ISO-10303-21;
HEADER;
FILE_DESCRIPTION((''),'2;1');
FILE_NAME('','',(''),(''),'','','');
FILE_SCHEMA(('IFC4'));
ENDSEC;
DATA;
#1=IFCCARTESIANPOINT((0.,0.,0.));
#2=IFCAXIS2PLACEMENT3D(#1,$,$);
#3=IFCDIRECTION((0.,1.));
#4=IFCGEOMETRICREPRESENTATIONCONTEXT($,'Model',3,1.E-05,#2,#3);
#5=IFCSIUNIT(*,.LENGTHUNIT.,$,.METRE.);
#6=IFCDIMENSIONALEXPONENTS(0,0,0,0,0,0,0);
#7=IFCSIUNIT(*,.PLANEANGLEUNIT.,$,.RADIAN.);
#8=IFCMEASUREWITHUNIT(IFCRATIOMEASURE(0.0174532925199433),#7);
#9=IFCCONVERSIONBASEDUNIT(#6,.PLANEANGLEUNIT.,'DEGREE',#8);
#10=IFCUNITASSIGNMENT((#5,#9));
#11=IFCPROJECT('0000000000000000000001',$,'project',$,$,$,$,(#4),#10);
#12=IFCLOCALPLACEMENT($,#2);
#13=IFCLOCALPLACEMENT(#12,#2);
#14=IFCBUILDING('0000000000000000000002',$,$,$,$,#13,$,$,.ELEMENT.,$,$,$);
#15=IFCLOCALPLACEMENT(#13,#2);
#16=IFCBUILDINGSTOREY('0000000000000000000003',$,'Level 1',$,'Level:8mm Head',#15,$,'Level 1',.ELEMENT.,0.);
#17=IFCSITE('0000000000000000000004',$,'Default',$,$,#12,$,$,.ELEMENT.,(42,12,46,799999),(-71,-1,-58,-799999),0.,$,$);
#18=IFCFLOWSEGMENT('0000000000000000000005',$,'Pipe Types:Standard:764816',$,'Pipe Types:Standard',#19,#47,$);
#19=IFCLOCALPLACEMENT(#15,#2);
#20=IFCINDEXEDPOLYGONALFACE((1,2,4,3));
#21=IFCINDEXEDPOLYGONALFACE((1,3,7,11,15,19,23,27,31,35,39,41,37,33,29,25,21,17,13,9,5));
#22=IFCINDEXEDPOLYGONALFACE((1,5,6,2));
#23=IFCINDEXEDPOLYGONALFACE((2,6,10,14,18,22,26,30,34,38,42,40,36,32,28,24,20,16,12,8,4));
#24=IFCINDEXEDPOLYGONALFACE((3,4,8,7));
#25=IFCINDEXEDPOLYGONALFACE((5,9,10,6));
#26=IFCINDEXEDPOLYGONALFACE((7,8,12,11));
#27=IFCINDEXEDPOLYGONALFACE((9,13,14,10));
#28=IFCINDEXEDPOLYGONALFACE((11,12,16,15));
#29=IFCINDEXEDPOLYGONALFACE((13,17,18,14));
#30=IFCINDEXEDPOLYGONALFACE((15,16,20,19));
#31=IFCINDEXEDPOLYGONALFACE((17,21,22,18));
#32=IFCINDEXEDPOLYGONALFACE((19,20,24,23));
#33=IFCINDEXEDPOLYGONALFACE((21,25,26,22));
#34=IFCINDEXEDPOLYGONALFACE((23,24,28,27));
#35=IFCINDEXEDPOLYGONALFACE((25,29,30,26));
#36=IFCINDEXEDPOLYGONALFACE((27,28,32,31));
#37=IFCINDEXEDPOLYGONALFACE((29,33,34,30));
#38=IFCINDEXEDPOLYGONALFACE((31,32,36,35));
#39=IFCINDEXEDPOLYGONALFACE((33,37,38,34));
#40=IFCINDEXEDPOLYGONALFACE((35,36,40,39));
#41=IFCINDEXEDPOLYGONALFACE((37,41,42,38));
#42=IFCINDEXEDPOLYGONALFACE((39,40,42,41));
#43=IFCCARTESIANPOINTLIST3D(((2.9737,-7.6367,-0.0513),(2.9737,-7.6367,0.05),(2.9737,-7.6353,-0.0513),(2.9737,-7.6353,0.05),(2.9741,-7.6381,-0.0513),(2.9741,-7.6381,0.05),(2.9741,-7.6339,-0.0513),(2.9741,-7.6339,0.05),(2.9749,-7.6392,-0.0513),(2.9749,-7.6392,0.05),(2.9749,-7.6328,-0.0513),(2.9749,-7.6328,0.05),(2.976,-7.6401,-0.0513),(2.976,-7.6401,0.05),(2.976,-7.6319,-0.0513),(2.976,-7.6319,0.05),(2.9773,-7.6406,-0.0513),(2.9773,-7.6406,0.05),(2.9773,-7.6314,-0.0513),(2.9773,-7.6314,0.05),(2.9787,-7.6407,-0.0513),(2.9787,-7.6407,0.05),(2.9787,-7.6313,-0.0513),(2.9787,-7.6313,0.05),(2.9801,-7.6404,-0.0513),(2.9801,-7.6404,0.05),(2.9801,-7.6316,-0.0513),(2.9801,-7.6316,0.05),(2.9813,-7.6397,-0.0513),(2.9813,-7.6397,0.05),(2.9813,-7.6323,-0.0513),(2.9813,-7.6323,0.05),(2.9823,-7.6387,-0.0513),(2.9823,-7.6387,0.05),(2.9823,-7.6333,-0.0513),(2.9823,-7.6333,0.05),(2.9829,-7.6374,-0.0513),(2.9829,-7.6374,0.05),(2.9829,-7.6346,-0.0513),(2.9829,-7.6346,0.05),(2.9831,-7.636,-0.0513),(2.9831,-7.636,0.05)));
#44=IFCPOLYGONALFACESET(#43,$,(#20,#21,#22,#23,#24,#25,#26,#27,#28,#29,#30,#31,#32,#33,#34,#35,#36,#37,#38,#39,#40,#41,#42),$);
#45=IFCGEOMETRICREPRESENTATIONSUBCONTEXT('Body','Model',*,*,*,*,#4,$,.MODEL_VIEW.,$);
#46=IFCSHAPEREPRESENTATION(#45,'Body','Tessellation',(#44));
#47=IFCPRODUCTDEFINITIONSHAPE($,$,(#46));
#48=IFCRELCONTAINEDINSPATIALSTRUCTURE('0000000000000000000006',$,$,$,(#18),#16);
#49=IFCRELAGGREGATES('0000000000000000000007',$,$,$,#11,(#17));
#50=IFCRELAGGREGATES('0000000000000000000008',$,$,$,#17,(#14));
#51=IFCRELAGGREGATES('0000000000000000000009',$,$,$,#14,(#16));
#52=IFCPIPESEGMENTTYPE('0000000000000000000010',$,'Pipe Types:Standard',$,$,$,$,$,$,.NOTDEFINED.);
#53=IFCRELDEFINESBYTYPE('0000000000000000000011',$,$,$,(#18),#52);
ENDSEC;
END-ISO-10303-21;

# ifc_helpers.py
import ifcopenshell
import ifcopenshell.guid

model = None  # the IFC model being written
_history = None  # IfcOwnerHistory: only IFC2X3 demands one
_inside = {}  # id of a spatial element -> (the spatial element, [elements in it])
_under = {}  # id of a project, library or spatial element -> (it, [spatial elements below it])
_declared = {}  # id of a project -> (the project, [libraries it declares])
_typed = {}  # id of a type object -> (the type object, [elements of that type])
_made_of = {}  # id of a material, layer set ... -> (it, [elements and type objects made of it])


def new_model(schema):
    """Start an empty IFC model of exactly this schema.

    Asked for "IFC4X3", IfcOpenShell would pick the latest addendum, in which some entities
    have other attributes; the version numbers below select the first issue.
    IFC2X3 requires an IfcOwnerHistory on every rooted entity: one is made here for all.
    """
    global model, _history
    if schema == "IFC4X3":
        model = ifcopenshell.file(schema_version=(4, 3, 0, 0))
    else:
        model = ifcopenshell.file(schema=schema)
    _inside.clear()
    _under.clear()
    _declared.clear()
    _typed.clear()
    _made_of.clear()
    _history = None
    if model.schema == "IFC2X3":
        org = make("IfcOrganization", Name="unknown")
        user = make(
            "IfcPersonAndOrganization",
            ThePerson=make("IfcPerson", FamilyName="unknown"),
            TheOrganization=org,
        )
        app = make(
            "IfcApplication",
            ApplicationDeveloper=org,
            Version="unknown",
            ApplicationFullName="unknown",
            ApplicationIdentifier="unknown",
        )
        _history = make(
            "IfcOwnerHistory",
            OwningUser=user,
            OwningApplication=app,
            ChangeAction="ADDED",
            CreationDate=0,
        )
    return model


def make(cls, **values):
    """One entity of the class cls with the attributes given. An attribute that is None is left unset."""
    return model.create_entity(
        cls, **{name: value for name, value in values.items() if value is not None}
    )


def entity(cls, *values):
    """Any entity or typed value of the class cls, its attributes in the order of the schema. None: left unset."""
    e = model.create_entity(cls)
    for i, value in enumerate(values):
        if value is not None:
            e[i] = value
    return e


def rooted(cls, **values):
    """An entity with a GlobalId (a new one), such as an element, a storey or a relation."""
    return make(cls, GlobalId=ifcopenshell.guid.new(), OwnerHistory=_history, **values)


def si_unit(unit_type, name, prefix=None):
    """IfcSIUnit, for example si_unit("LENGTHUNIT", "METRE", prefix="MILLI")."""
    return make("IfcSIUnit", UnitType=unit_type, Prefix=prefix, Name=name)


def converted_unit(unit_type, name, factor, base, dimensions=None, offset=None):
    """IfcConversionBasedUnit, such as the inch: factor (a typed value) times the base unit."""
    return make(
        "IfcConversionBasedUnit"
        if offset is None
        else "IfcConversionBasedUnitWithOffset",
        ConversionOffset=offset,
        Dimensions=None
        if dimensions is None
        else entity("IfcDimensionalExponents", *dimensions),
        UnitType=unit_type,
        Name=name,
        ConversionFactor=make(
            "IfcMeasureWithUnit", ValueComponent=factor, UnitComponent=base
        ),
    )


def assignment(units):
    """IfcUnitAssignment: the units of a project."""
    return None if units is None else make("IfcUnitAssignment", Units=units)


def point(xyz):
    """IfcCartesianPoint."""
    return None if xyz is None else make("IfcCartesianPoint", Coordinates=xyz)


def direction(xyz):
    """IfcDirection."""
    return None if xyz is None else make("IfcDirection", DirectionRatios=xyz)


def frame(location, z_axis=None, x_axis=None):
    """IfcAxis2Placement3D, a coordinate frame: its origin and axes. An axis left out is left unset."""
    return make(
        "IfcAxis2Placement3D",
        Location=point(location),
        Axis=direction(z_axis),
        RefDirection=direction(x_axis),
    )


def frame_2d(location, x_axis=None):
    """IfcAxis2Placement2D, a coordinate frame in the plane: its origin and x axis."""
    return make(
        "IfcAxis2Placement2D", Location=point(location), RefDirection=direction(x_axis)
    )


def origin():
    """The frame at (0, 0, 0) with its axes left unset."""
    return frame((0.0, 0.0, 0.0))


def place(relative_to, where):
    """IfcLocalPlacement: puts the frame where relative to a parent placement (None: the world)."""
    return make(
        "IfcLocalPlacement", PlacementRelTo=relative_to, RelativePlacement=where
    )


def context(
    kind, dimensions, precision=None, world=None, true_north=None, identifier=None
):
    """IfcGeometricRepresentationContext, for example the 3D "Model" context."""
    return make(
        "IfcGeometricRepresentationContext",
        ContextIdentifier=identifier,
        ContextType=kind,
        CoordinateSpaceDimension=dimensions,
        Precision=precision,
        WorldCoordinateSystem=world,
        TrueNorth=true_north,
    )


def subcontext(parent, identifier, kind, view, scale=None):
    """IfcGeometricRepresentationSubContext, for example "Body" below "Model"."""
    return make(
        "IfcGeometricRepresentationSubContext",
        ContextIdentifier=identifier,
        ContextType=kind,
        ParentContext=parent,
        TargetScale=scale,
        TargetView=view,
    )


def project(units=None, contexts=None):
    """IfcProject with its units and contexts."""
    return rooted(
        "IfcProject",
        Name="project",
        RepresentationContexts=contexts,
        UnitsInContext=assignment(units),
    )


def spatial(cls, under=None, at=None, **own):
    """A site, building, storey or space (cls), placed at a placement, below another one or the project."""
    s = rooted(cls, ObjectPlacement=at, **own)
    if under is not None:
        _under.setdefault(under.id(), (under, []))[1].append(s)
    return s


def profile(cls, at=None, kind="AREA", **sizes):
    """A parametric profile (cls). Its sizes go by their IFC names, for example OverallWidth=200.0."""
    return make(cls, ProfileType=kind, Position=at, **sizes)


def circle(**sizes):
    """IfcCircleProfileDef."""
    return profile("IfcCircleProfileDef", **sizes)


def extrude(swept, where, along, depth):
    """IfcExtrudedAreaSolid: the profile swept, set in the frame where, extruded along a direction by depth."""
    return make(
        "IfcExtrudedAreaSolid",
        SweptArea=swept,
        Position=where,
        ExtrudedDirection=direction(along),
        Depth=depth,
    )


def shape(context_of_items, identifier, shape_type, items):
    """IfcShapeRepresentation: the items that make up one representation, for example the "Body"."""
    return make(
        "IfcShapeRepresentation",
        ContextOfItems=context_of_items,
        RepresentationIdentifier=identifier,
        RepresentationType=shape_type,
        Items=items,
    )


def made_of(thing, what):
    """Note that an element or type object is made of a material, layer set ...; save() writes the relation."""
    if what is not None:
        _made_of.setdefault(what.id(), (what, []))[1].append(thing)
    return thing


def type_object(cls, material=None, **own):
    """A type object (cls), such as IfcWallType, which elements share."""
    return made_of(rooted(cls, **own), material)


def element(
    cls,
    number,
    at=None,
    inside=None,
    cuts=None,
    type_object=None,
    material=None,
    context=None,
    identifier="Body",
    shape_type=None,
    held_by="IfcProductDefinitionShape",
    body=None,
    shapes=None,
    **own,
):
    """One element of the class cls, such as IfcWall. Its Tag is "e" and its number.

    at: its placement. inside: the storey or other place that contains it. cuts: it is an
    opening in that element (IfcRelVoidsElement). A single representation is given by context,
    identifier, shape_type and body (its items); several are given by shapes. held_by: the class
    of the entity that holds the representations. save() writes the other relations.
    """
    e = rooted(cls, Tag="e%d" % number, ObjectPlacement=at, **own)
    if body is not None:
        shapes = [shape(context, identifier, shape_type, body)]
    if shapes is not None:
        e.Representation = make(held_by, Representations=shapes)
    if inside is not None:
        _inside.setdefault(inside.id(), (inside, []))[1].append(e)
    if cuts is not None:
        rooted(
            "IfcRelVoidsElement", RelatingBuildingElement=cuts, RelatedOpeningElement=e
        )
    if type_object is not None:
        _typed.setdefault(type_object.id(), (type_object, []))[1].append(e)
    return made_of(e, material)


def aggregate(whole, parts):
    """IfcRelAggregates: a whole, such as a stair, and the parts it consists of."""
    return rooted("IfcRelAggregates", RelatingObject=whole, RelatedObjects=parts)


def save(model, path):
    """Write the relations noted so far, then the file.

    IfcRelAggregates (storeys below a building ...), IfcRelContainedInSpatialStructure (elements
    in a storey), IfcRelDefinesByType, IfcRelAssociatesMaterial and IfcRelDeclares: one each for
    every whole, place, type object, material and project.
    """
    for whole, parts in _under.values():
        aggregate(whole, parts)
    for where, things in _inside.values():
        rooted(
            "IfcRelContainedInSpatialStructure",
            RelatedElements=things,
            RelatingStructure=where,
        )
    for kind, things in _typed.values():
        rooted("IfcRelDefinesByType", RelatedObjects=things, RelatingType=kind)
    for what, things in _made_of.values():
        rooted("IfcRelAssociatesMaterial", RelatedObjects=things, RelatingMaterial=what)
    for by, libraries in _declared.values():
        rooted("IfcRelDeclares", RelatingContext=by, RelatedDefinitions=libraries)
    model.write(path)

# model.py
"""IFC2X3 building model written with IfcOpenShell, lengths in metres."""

from ifc_helpers import new_model, entity, si_unit, converted_unit, direction, frame, frame_2d, origin, place, context, subcontext, project, spatial, circle, extrude, type_object, element, save


model = new_model("IFC2X3")

# Units and contexts
model_context = context("Model", 3, precision=1e-05, world=origin(), true_north=direction((0.0, 1.0)))
body_context = subcontext(model_context, "Body", "Model", "MODEL_VIEW")
ifc_project = project(units=[si_unit("LENGTHUNIT", "METRE"), converted_unit("PLANEANGLEUNIT", "DEGREE", entity("IfcRatioMeasure", 0.0174532925199433), si_unit("PLANEANGLEUNIT", "RADIAN"), dimensions=[0, 0, 0, 0, 0, 0, 0])], contexts=[model_context])

# Site, building, storey
site_placement = place(None, origin())
site = spatial("IfcSite", under=ifc_project, at=site_placement, Name="Default", CompositionType="ELEMENT", RefLatitude=(42, 12, 46, 799999), RefLongitude=(-71, -1, -58, -799999), RefElevation=0.0)
building_placement = place(site_placement, origin())
building = spatial("IfcBuilding", under=site, at=building_placement, CompositionType="ELEMENT")
storey_placement = place(building_placement, origin())
storey = spatial("IfcBuildingStorey", under=building, at=storey_placement, Name="Level 1", ObjectType="Level:8mm Head", LongName="Level 1", CompositionType="ELEMENT", Elevation=0.0)

# Flow segment
pipe_segment_type = type_object("IfcPipeSegmentType", Name="Pipe Types:Standard", PredefinedType="NOTDEFINED")
flow_segment_1_placement = place(storey_placement, origin())
element("IfcFlowSegment", 1, at=flow_segment_1_placement, inside=storey, type_object=pipe_segment_type, Name="Pipe Types:Standard:764816", ObjectType="Pipe Types:Standard", context=body_context, shape_type="SweptSolid", body=[
    extrude(circle(Radius=0.0048, at=frame_2d((0.0, 0.0), x_axis=(1.0, 0.0))), frame((2.9784, -7.636, -0.0513)), (0.0, 0.0, 1.0), 0.1013),
])

save(model, "model.ifc")
